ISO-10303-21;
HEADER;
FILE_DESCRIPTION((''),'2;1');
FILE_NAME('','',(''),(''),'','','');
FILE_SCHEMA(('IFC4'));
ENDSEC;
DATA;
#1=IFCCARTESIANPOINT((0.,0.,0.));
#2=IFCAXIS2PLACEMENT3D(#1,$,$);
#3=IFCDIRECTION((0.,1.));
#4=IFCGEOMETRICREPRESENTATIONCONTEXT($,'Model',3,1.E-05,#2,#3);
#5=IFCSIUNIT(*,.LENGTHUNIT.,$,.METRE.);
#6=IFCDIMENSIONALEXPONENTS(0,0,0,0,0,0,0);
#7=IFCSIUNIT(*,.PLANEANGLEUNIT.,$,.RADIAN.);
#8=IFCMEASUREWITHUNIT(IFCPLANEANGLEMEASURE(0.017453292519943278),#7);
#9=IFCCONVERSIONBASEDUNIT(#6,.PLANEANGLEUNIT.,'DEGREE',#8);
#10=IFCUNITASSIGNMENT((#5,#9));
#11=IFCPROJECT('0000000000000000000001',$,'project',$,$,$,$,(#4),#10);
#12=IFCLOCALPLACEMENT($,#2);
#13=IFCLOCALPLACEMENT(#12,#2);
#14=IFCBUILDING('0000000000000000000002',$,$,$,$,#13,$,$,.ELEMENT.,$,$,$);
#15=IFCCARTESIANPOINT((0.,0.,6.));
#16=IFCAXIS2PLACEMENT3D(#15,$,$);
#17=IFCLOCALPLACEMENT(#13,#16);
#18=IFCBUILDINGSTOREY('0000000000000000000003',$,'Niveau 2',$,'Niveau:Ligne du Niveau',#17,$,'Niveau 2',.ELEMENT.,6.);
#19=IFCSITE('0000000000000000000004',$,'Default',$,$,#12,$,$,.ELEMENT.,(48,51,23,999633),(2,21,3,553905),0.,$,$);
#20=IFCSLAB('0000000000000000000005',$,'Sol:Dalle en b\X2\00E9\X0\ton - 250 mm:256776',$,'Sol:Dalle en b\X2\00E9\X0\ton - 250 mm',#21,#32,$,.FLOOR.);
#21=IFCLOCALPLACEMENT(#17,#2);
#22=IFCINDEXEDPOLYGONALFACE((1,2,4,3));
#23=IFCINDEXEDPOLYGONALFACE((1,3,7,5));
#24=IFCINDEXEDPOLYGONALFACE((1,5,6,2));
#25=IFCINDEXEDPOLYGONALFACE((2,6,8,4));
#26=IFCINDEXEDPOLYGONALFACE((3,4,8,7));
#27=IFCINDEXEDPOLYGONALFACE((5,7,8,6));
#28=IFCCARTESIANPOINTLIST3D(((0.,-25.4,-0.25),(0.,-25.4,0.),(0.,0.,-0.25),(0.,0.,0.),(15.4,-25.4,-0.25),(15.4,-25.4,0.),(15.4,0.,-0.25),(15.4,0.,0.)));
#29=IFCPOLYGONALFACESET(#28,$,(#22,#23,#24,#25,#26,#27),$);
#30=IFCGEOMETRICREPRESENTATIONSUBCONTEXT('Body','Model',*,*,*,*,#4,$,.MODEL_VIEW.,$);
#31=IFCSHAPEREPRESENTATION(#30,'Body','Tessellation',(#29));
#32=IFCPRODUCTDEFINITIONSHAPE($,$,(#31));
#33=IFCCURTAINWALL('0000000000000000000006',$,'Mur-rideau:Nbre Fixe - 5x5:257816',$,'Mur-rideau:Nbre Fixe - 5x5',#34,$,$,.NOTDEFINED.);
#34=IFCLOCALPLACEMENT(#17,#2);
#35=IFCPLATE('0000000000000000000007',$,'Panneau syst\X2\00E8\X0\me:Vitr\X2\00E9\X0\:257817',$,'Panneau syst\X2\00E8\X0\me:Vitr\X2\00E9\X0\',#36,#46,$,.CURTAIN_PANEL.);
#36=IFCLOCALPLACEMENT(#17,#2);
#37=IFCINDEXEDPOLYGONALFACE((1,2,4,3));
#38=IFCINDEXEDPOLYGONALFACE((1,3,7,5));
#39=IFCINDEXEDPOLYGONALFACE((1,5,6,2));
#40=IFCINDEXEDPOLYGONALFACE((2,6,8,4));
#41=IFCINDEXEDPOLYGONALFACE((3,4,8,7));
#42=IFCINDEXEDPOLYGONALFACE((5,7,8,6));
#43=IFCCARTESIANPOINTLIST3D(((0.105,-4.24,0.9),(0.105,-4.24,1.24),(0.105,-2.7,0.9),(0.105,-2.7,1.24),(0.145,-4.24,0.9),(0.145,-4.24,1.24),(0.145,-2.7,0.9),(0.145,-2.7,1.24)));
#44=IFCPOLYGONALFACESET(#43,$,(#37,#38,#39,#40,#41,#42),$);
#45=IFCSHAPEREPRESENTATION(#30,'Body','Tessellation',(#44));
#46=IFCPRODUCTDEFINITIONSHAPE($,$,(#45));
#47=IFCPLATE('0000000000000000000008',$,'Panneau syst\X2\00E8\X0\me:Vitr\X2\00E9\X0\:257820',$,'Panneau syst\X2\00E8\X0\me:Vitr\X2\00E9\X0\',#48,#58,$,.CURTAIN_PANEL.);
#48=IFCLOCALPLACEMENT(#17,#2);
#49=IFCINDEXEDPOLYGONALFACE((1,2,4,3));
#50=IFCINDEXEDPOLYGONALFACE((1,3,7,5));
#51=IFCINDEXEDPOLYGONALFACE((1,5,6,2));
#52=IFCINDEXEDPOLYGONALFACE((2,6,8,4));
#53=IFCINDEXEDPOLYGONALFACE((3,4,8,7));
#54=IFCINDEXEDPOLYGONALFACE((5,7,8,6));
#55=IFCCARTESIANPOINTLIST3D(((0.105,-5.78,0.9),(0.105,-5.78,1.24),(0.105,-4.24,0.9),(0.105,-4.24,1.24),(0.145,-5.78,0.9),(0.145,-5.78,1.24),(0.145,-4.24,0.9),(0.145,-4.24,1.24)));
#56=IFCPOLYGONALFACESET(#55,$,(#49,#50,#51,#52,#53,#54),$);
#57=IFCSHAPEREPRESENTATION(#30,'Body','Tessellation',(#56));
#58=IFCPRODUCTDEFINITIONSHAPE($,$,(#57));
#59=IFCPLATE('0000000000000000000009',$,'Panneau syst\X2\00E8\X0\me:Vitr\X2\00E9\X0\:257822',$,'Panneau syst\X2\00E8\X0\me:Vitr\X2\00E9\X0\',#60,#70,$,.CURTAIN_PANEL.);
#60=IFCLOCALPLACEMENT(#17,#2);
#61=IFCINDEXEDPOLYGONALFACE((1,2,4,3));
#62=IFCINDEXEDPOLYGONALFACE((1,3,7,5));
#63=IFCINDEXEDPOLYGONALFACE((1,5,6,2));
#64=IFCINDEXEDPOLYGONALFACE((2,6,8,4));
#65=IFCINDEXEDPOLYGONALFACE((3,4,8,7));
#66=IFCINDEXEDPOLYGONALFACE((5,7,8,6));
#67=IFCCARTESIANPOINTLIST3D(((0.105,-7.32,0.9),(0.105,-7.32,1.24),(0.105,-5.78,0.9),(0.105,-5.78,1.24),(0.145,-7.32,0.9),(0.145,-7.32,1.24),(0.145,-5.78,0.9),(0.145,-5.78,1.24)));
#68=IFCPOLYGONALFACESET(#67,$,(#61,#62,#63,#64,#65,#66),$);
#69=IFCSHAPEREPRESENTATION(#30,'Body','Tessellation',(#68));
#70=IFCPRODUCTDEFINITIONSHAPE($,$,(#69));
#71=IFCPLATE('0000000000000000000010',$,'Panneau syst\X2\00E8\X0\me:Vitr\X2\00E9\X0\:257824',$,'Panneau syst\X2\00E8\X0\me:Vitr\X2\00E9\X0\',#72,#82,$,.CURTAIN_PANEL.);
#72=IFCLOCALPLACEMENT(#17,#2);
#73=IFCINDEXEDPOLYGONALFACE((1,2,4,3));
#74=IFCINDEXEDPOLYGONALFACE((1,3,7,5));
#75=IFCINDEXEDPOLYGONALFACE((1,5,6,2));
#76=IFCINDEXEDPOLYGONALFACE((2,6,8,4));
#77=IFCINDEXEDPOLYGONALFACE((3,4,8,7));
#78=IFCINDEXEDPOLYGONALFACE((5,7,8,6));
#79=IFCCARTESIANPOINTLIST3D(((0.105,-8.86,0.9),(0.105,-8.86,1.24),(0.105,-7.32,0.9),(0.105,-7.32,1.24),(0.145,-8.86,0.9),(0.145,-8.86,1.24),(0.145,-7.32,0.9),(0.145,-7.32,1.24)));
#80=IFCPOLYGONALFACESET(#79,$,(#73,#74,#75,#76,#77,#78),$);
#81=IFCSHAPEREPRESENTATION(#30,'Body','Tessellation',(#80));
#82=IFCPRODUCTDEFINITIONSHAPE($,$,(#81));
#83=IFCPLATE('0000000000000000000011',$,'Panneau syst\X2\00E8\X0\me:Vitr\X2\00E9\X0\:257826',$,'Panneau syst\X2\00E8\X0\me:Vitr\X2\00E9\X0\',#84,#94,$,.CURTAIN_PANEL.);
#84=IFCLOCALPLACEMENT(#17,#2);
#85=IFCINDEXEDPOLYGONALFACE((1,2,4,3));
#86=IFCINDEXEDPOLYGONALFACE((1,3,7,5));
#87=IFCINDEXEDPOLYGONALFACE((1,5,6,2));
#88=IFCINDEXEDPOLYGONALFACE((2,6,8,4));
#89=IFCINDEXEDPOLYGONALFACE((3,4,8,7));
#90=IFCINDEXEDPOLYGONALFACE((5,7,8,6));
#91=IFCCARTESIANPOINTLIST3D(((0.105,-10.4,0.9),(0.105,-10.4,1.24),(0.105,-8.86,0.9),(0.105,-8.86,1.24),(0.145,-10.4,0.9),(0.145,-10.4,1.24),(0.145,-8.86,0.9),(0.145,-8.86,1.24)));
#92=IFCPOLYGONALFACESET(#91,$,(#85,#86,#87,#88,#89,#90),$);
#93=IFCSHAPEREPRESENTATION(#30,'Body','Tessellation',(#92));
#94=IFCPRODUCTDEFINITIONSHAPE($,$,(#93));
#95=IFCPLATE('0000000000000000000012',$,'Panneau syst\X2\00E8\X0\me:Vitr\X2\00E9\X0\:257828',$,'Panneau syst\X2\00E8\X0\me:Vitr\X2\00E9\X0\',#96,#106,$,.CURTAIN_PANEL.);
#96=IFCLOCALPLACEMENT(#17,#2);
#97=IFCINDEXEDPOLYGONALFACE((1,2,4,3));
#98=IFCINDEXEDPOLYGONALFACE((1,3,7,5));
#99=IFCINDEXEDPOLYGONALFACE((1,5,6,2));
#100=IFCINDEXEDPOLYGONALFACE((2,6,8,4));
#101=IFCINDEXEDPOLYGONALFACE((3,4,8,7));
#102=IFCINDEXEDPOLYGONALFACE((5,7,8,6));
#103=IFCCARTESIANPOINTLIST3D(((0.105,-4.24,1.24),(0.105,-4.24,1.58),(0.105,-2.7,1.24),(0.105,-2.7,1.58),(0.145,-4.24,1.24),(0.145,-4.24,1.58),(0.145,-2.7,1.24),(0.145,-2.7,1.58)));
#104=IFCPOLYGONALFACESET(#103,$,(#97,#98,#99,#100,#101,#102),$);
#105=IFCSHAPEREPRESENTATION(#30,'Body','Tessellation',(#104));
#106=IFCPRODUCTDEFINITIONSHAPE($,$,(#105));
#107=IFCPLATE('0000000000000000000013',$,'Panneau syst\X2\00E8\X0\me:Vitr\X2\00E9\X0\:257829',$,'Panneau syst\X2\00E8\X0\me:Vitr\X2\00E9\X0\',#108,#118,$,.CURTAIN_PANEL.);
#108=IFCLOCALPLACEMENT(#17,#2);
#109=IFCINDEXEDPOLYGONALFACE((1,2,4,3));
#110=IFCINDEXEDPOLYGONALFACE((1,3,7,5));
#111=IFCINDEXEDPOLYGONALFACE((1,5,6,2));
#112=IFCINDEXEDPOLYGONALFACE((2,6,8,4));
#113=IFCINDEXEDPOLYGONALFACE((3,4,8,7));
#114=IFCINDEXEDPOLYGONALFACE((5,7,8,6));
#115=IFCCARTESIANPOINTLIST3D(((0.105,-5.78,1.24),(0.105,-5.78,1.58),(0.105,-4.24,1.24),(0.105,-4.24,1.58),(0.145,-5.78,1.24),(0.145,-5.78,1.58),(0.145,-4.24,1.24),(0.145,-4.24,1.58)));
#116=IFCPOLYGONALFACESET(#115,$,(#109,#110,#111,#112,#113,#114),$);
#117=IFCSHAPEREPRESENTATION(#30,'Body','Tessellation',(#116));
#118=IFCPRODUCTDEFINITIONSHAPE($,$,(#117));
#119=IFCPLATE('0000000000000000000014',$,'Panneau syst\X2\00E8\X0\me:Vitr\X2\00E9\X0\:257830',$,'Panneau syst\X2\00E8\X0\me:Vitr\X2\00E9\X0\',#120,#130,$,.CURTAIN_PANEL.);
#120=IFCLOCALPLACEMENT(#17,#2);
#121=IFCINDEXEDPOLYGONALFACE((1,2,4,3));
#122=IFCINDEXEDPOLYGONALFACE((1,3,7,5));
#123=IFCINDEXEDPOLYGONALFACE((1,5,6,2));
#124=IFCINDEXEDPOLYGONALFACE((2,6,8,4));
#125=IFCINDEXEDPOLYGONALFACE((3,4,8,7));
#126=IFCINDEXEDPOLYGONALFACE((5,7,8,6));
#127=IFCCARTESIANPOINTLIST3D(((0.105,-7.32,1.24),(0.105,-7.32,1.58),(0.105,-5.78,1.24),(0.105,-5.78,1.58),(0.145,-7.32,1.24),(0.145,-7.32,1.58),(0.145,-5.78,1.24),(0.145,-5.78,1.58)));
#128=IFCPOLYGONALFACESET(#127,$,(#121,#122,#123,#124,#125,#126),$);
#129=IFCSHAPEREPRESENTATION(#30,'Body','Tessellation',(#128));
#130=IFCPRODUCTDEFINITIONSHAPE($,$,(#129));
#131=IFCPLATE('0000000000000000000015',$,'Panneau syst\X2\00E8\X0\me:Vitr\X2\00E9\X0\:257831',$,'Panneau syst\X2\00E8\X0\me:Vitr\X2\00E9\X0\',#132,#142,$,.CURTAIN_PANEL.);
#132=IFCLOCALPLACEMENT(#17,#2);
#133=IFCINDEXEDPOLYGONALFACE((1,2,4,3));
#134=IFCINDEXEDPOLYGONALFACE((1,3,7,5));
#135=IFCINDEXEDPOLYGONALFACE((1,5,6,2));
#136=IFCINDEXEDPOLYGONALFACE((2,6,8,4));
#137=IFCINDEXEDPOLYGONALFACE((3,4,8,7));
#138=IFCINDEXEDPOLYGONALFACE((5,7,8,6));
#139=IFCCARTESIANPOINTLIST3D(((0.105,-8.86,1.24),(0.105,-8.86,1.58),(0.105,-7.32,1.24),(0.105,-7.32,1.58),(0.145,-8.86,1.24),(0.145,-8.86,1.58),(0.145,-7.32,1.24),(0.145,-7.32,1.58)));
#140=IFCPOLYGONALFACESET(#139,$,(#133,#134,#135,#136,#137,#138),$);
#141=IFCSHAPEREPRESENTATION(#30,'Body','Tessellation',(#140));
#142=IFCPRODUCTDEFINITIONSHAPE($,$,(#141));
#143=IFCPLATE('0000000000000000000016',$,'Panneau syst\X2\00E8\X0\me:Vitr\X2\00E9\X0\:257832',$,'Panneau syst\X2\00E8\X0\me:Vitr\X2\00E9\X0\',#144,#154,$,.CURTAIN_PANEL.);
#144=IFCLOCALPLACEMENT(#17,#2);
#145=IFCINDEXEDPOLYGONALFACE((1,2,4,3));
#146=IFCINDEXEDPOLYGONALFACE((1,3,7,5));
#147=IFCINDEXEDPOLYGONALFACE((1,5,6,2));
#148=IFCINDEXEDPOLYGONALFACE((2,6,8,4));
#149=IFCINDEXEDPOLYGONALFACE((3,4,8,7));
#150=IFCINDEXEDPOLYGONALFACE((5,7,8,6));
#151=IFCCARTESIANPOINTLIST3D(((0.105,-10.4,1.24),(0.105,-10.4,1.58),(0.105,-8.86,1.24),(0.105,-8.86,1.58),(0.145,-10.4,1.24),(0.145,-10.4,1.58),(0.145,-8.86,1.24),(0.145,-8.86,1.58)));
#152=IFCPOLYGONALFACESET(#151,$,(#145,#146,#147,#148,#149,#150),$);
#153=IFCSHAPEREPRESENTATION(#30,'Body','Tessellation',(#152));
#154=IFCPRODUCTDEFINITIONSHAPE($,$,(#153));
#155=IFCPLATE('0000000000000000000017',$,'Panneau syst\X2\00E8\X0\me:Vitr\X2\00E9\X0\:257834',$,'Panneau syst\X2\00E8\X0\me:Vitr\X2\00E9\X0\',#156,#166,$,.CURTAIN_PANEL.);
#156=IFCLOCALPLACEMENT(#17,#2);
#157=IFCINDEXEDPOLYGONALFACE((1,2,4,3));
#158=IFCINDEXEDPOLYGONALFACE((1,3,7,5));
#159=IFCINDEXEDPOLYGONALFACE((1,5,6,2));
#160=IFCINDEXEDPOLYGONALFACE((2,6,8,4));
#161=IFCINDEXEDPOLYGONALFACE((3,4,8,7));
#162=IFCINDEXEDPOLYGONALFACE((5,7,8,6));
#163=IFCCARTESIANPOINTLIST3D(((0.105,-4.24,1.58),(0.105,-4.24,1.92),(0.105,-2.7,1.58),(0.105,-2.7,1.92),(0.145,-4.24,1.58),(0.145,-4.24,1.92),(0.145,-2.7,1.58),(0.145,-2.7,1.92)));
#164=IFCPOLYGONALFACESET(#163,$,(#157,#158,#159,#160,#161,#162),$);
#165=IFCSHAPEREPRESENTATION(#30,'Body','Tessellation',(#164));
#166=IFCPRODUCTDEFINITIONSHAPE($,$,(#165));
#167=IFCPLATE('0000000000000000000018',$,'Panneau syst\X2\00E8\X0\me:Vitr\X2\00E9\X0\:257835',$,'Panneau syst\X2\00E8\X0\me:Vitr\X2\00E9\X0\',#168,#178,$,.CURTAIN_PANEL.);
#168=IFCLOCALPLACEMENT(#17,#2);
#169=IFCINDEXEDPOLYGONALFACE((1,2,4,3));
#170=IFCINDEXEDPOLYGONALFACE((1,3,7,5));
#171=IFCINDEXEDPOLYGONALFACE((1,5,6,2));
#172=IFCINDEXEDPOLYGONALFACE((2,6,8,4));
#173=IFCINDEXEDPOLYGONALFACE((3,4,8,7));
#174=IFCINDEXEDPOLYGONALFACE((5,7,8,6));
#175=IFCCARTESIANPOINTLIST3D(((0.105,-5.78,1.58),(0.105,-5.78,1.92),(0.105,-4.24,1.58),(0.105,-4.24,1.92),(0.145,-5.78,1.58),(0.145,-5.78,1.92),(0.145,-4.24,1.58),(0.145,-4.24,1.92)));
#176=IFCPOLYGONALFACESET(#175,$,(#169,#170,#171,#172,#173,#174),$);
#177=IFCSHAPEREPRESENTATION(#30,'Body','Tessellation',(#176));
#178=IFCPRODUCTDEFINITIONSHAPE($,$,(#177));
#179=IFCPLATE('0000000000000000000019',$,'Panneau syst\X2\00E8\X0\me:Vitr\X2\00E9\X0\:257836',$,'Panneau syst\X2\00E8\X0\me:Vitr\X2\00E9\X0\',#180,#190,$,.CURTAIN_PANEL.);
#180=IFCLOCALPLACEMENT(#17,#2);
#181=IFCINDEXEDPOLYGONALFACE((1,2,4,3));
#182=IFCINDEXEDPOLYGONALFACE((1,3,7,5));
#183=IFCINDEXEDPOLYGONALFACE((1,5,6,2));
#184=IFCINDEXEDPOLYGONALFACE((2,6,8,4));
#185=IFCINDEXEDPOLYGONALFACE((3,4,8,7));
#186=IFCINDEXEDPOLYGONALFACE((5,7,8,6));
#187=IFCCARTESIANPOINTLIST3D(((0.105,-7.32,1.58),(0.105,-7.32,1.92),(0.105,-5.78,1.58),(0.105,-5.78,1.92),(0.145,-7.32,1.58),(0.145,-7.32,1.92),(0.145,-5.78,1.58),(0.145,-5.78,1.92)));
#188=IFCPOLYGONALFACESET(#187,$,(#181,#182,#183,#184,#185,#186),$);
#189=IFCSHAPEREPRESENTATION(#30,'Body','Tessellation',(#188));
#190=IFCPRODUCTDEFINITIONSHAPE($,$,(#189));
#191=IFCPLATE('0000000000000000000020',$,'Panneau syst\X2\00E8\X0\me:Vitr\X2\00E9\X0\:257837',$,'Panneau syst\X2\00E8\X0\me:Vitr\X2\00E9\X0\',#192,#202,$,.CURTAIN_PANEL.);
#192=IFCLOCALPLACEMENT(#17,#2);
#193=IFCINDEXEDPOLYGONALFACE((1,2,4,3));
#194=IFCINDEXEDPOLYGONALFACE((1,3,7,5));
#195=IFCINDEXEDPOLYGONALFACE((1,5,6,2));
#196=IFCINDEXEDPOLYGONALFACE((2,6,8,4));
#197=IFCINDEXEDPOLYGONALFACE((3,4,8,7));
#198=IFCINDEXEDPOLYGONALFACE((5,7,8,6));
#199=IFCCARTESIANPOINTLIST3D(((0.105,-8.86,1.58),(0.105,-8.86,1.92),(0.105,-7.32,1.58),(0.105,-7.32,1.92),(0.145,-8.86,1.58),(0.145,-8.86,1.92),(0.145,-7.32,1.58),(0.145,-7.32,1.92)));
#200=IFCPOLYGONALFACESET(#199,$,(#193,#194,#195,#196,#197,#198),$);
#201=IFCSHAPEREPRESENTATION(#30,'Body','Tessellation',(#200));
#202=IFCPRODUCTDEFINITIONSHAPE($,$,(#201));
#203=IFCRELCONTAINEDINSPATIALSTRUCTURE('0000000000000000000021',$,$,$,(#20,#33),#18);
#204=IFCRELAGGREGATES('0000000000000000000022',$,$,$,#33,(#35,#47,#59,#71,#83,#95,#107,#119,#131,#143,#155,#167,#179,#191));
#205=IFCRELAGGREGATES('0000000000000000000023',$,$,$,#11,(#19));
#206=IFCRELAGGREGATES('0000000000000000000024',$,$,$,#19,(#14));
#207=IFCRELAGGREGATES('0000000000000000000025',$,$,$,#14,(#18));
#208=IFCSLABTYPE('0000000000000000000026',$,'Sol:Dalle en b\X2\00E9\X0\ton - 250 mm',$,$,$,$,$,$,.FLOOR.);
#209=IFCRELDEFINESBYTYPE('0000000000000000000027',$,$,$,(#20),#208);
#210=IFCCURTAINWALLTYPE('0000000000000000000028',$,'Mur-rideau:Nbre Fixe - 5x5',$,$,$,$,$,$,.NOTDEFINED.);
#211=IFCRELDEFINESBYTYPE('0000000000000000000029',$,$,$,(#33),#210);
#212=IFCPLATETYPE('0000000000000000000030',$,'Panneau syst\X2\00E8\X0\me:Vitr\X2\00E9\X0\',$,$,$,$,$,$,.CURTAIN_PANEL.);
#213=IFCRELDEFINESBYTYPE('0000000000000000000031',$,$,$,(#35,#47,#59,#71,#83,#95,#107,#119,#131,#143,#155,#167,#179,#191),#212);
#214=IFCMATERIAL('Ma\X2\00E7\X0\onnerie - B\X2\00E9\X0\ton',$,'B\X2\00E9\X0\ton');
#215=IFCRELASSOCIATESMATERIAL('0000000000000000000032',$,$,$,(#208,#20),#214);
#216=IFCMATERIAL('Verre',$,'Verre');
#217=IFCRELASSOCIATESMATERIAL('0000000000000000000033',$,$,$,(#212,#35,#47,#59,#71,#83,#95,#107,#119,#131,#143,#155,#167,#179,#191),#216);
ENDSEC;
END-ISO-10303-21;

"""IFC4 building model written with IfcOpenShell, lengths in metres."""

from ifc_helpers import new_model, entity, si_unit, converted_unit, direction, frame, origin, place, context, subcontext, project, spatial, indexed_curve, outline, extrude, source, transform, mapped, material, type_object, type_shapes, element, aggregate, save


model = new_model("IFC4")

# Units and contexts
model_context = context("Model", 3, precision=1e-05, world=origin(), true_north=direction((0.0, 1.0)))
body_context = subcontext(model_context, "Body", "Model", "MODEL_VIEW")
ifc_project = project(units=[si_unit("LENGTHUNIT", "METRE"), converted_unit("PLANEANGLEUNIT", "DEGREE", entity("IfcPlaneAngleMeasure", 0.017453292519943278), si_unit("PLANEANGLEUNIT", "RADIAN"), dimensions=[0, 0, 0, 0, 0, 0, 0])], contexts=[model_context])

# Site, building, storey
site_placement = place(None, origin())
site = spatial("IfcSite", under=ifc_project, at=site_placement, Name="Default", CompositionType="ELEMENT", RefLatitude=(48, 51, 23, 999633), RefLongitude=(2, 21, 3, 553905), RefElevation=0.0)
building_placement = place(site_placement, origin())
building = spatial("IfcBuilding", under=site, at=building_placement, CompositionType="ELEMENT")
storey_placement = place(building_placement, frame((0.0, 0.0, 6.0)))
storey = spatial("IfcBuildingStorey", under=building, at=storey_placement, Name="Niveau 2", ObjectType="Niveau:Ligne du Niveau", LongName="Niveau 2", CompositionType="ELEMENT", Elevation=6.0)

# Slab
ifc_material_1 = material(Name="Maçonnerie - Béton", Category="Béton")
slab_type = type_object("IfcSlabType", Name="Sol:Dalle en béton - 250 mm", PredefinedType="FLOOR", material=ifc_material_1)
slab_placement = place(storey_placement, origin())
element("IfcSlab", 1, at=slab_placement, inside=storey, type_object=slab_type, material=ifc_material_1, Name="Sol:Dalle en béton - 250 mm:256776", ObjectType="Sol:Dalle en béton - 250 mm", PredefinedType="FLOOR", context=body_context, shape_type="SweptSolid", body=[
    extrude(outline(indexed_curve([(-12.7, -7.7), (12.7, -7.7), (12.7, 7.7), (-12.7, 7.7), (-12.7, -7.7)], self_intersect=False)), frame((7.7, -12.7, 0.0), z_axis=(0.0, 0.0, -1.0), x_axis=(0.0, 1.0, 0.0)), (0.0, 0.0, 1.0), 0.25),
])

# Curtain wall, plates
curtain_wall_type = type_object("IfcCurtainWallType", Name="Mur-rideau:Nbre Fixe - 5x5", PredefinedType="NOTDEFINED")
curtain_wall_placement = place(storey_placement, frame((0.0, 0.0, -6.0)))
curtain_wall = element("IfcCurtainWall", 2, at=curtain_wall_placement, inside=storey, type_object=curtain_wall_type, Name="Mur-rideau:Nbre Fixe - 5x5:257816", ObjectType="Mur-rideau:Nbre Fixe - 5x5", PredefinedType="NOTDEFINED")
ifc_material_2 = material(Name="Verre", Category="Verre")
plate_type = type_object("IfcPlateType", Name="Panneau système:Vitré", PredefinedType="CURTAIN_PANEL", material=ifc_material_2)
shared_shape = source(origin(), body_context, "Body", "SweptSolid", [
    extrude(outline(indexed_curve([(-0.02, -0.77), (0.02, -0.77), (0.02, 0.77), (-0.02, 0.77), (-0.02, -0.77)], self_intersect=False)), frame((0.77, 0.02, 0.0), z_axis=(0.0, 0.0, 1.0), x_axis=(0.0, 1.0, 0.0)), (0.0, 0.0, 1.0), 0.34),
])
type_shapes(plate_type, [shared_shape])
plate_1_placement = place(curtain_wall_placement, frame((0.105, -2.7, 6.9), z_axis=(0.0, 0.0, 1.0), x_axis=(0.0, -1.0, 0.0)))
plate_1 = element("IfcPlate", 3, at=plate_1_placement, type_object=plate_type, material=ifc_material_2, Name="Panneau système:Vitré:257817", ObjectType="Panneau système:Vitré", PredefinedType="CURTAIN_PANEL", context=body_context, shape_type="MappedRepresentation", body=[
    mapped(shared_shape, transform((0.0, 0.0, 0.0), scale=1.0)),
])
plate_2_placement = place(curtain_wall_placement, frame((0.105, -4.24, 6.9), z_axis=(0.0, 0.0, 1.0), x_axis=(0.0, -1.0, 0.0)))
plate_2 = element("IfcPlate", 4, at=plate_2_placement, type_object=plate_type, material=ifc_material_2, Name="Panneau système:Vitré:257820", ObjectType="Panneau système:Vitré", PredefinedType="CURTAIN_PANEL", context=body_context, shape_type="MappedRepresentation", body=[
    mapped(shared_shape, transform((0.0, 0.0, 0.0), scale=1.0)),
])
plate_3_placement = place(curtain_wall_placement, frame((0.105, -5.78, 6.9), z_axis=(0.0, 0.0, 1.0), x_axis=(0.0, -1.0, 0.0)))
plate_3 = element("IfcPlate", 5, at=plate_3_placement, type_object=plate_type, material=ifc_material_2, Name="Panneau système:Vitré:257822", ObjectType="Panneau système:Vitré", PredefinedType="CURTAIN_PANEL", context=body_context, shape_type="MappedRepresentation", body=[
    mapped(shared_shape, transform((0.0, 0.0, 0.0), scale=1.0)),
])
plate_4_placement = place(curtain_wall_placement, frame((0.105, -7.32, 6.9), z_axis=(0.0, 0.0, 1.0), x_axis=(0.0, -1.0, 0.0)))
plate_4 = element("IfcPlate", 6, at=plate_4_placement, type_object=plate_type, material=ifc_material_2, Name="Panneau système:Vitré:257824", ObjectType="Panneau système:Vitré", PredefinedType="CURTAIN_PANEL", context=body_context, shape_type="MappedRepresentation", body=[
    mapped(shared_shape, transform((0.0, 0.0, 0.0), scale=1.0)),
])
plate_5_placement = place(curtain_wall_placement, frame((0.105, -8.86, 6.9), z_axis=(0.0, 0.0, 1.0), x_axis=(0.0, -1.0, 0.0)))
plate_5 = element("IfcPlate", 7, at=plate_5_placement, type_object=plate_type, material=ifc_material_2, Name="Panneau système:Vitré:257826", ObjectType="Panneau système:Vitré", PredefinedType="CURTAIN_PANEL", context=body_context, shape_type="MappedRepresentation", body=[
    mapped(shared_shape, transform((0.0, 0.0, 0.0), scale=1.0)),
])
plate_6_placement = place(curtain_wall_placement, frame((0.105, -2.7, 7.24), z_axis=(0.0, 0.0, 1.0), x_axis=(0.0, -1.0, 0.0)))
plate_6 = element("IfcPlate", 8, at=plate_6_placement, type_object=plate_type, material=ifc_material_2, Name="Panneau système:Vitré:257828", ObjectType="Panneau système:Vitré", PredefinedType="CURTAIN_PANEL", context=body_context, shape_type="MappedRepresentation", body=[
    mapped(shared_shape, transform((0.0, 0.0, 0.0), scale=1.0)),
])
plate_7_placement = place(curtain_wall_placement, frame((0.105, -4.24, 7.24), z_axis=(0.0, 0.0, 1.0), x_axis=(0.0, -1.0, 0.0)))
plate_7 = element("IfcPlate", 9, at=plate_7_placement, type_object=plate_type, material=ifc_material_2, Name="Panneau système:Vitré:257829", ObjectType="Panneau système:Vitré", PredefinedType="CURTAIN_PANEL", context=body_context, shape_type="MappedRepresentation", body=[
    mapped(shared_shape, transform((0.0, 0.0, 0.0), scale=1.0)),
])
plate_8_placement = place(curtain_wall_placement, frame((0.105, -5.78, 7.24), z_axis=(0.0, 0.0, 1.0), x_axis=(0.0, -1.0, 0.0)))
plate_8 = element("IfcPlate", 10, at=plate_8_placement, type_object=plate_type, material=ifc_material_2, Name="Panneau système:Vitré:257830", ObjectType="Panneau système:Vitré", PredefinedType="CURTAIN_PANEL", context=body_context, shape_type="MappedRepresentation", body=[
    mapped(shared_shape, transform((0.0, 0.0, 0.0), scale=1.0)),
])
plate_9_placement = place(curtain_wall_placement, frame((0.105, -7.32, 7.24), z_axis=(0.0, 0.0, 1.0), x_axis=(0.0, -1.0, 0.0)))
plate_9 = element("IfcPlate", 11, at=plate_9_placement, type_object=plate_type, material=ifc_material_2, Name="Panneau système:Vitré:257831", ObjectType="Panneau système:Vitré", PredefinedType="CURTAIN_PANEL", context=body_context, shape_type="MappedRepresentation", body=[
    mapped(shared_shape, transform((0.0, 0.0, 0.0), scale=1.0)),
])
plate_10_placement = place(curtain_wall_placement, frame((0.105, -8.86, 7.24), z_axis=(0.0, 0.0, 1.0), x_axis=(0.0, -1.0, 0.0)))
plate_10 = element("IfcPlate", 12, at=plate_10_placement, type_object=plate_type, material=ifc_material_2, Name="Panneau système:Vitré:257832", ObjectType="Panneau système:Vitré", PredefinedType="CURTAIN_PANEL", context=body_context, shape_type="MappedRepresentation", body=[
    mapped(shared_shape, transform((0.0, 0.0, 0.0), scale=1.0)),
])
plate_11_placement = place(curtain_wall_placement, frame((0.105, -2.7, 7.58), z_axis=(0.0, 0.0, 1.0), x_axis=(0.0, -1.0, 0.0)))
plate_11 = element("IfcPlate", 13, at=plate_11_placement, type_object=plate_type, material=ifc_material_2, Name="Panneau système:Vitré:257834", ObjectType="Panneau système:Vitré", PredefinedType="CURTAIN_PANEL", context=body_context, shape_type="MappedRepresentation", body=[
    mapped(shared_shape, transform((0.0, 0.0, 0.0), scale=1.0)),
])
plate_12_placement = place(curtain_wall_placement, frame((0.105, -4.24, 7.58), z_axis=(0.0, 0.0, 1.0), x_axis=(0.0, -1.0, 0.0)))
plate_12 = element("IfcPlate", 14, at=plate_12_placement, type_object=plate_type, material=ifc_material_2, Name="Panneau système:Vitré:257835", ObjectType="Panneau système:Vitré", PredefinedType="CURTAIN_PANEL", context=body_context, shape_type="MappedRepresentation", body=[
    mapped(shared_shape, transform((0.0, 0.0, 0.0), scale=1.0)),
])
plate_13_placement = place(curtain_wall_placement, frame((0.105, -5.78, 7.58), z_axis=(0.0, 0.0, 1.0), x_axis=(0.0, -1.0, 0.0)))
plate_13 = element("IfcPlate", 15, at=plate_13_placement, type_object=plate_type, material=ifc_material_2, Name="Panneau système:Vitré:257836", ObjectType="Panneau système:Vitré", PredefinedType="CURTAIN_PANEL", context=body_context, shape_type="MappedRepresentation", body=[
    mapped(shared_shape, transform((0.0, 0.0, 0.0), scale=1.0)),
])
plate_14_placement = place(curtain_wall_placement, frame((0.105, -7.32, 7.58), z_axis=(0.0, 0.0, 1.0), x_axis=(0.0, -1.0, 0.0)))
plate_14 = element("IfcPlate", 16, at=plate_14_placement, type_object=plate_type, material=ifc_material_2, Name="Panneau système:Vitré:257837", ObjectType="Panneau système:Vitré", PredefinedType="CURTAIN_PANEL", context=body_context, shape_type="MappedRepresentation", body=[
    mapped(shared_shape, transform((0.0, 0.0, 0.0), scale=1.0)),
])
aggregate(curtain_wall, [plate_1, plate_2, plate_3, plate_4, plate_5, plate_6, plate_7, plate_8, plate_9, plate_10, plate_11, plate_12, plate_13, plate_14])

save(model, "model.ifc")
